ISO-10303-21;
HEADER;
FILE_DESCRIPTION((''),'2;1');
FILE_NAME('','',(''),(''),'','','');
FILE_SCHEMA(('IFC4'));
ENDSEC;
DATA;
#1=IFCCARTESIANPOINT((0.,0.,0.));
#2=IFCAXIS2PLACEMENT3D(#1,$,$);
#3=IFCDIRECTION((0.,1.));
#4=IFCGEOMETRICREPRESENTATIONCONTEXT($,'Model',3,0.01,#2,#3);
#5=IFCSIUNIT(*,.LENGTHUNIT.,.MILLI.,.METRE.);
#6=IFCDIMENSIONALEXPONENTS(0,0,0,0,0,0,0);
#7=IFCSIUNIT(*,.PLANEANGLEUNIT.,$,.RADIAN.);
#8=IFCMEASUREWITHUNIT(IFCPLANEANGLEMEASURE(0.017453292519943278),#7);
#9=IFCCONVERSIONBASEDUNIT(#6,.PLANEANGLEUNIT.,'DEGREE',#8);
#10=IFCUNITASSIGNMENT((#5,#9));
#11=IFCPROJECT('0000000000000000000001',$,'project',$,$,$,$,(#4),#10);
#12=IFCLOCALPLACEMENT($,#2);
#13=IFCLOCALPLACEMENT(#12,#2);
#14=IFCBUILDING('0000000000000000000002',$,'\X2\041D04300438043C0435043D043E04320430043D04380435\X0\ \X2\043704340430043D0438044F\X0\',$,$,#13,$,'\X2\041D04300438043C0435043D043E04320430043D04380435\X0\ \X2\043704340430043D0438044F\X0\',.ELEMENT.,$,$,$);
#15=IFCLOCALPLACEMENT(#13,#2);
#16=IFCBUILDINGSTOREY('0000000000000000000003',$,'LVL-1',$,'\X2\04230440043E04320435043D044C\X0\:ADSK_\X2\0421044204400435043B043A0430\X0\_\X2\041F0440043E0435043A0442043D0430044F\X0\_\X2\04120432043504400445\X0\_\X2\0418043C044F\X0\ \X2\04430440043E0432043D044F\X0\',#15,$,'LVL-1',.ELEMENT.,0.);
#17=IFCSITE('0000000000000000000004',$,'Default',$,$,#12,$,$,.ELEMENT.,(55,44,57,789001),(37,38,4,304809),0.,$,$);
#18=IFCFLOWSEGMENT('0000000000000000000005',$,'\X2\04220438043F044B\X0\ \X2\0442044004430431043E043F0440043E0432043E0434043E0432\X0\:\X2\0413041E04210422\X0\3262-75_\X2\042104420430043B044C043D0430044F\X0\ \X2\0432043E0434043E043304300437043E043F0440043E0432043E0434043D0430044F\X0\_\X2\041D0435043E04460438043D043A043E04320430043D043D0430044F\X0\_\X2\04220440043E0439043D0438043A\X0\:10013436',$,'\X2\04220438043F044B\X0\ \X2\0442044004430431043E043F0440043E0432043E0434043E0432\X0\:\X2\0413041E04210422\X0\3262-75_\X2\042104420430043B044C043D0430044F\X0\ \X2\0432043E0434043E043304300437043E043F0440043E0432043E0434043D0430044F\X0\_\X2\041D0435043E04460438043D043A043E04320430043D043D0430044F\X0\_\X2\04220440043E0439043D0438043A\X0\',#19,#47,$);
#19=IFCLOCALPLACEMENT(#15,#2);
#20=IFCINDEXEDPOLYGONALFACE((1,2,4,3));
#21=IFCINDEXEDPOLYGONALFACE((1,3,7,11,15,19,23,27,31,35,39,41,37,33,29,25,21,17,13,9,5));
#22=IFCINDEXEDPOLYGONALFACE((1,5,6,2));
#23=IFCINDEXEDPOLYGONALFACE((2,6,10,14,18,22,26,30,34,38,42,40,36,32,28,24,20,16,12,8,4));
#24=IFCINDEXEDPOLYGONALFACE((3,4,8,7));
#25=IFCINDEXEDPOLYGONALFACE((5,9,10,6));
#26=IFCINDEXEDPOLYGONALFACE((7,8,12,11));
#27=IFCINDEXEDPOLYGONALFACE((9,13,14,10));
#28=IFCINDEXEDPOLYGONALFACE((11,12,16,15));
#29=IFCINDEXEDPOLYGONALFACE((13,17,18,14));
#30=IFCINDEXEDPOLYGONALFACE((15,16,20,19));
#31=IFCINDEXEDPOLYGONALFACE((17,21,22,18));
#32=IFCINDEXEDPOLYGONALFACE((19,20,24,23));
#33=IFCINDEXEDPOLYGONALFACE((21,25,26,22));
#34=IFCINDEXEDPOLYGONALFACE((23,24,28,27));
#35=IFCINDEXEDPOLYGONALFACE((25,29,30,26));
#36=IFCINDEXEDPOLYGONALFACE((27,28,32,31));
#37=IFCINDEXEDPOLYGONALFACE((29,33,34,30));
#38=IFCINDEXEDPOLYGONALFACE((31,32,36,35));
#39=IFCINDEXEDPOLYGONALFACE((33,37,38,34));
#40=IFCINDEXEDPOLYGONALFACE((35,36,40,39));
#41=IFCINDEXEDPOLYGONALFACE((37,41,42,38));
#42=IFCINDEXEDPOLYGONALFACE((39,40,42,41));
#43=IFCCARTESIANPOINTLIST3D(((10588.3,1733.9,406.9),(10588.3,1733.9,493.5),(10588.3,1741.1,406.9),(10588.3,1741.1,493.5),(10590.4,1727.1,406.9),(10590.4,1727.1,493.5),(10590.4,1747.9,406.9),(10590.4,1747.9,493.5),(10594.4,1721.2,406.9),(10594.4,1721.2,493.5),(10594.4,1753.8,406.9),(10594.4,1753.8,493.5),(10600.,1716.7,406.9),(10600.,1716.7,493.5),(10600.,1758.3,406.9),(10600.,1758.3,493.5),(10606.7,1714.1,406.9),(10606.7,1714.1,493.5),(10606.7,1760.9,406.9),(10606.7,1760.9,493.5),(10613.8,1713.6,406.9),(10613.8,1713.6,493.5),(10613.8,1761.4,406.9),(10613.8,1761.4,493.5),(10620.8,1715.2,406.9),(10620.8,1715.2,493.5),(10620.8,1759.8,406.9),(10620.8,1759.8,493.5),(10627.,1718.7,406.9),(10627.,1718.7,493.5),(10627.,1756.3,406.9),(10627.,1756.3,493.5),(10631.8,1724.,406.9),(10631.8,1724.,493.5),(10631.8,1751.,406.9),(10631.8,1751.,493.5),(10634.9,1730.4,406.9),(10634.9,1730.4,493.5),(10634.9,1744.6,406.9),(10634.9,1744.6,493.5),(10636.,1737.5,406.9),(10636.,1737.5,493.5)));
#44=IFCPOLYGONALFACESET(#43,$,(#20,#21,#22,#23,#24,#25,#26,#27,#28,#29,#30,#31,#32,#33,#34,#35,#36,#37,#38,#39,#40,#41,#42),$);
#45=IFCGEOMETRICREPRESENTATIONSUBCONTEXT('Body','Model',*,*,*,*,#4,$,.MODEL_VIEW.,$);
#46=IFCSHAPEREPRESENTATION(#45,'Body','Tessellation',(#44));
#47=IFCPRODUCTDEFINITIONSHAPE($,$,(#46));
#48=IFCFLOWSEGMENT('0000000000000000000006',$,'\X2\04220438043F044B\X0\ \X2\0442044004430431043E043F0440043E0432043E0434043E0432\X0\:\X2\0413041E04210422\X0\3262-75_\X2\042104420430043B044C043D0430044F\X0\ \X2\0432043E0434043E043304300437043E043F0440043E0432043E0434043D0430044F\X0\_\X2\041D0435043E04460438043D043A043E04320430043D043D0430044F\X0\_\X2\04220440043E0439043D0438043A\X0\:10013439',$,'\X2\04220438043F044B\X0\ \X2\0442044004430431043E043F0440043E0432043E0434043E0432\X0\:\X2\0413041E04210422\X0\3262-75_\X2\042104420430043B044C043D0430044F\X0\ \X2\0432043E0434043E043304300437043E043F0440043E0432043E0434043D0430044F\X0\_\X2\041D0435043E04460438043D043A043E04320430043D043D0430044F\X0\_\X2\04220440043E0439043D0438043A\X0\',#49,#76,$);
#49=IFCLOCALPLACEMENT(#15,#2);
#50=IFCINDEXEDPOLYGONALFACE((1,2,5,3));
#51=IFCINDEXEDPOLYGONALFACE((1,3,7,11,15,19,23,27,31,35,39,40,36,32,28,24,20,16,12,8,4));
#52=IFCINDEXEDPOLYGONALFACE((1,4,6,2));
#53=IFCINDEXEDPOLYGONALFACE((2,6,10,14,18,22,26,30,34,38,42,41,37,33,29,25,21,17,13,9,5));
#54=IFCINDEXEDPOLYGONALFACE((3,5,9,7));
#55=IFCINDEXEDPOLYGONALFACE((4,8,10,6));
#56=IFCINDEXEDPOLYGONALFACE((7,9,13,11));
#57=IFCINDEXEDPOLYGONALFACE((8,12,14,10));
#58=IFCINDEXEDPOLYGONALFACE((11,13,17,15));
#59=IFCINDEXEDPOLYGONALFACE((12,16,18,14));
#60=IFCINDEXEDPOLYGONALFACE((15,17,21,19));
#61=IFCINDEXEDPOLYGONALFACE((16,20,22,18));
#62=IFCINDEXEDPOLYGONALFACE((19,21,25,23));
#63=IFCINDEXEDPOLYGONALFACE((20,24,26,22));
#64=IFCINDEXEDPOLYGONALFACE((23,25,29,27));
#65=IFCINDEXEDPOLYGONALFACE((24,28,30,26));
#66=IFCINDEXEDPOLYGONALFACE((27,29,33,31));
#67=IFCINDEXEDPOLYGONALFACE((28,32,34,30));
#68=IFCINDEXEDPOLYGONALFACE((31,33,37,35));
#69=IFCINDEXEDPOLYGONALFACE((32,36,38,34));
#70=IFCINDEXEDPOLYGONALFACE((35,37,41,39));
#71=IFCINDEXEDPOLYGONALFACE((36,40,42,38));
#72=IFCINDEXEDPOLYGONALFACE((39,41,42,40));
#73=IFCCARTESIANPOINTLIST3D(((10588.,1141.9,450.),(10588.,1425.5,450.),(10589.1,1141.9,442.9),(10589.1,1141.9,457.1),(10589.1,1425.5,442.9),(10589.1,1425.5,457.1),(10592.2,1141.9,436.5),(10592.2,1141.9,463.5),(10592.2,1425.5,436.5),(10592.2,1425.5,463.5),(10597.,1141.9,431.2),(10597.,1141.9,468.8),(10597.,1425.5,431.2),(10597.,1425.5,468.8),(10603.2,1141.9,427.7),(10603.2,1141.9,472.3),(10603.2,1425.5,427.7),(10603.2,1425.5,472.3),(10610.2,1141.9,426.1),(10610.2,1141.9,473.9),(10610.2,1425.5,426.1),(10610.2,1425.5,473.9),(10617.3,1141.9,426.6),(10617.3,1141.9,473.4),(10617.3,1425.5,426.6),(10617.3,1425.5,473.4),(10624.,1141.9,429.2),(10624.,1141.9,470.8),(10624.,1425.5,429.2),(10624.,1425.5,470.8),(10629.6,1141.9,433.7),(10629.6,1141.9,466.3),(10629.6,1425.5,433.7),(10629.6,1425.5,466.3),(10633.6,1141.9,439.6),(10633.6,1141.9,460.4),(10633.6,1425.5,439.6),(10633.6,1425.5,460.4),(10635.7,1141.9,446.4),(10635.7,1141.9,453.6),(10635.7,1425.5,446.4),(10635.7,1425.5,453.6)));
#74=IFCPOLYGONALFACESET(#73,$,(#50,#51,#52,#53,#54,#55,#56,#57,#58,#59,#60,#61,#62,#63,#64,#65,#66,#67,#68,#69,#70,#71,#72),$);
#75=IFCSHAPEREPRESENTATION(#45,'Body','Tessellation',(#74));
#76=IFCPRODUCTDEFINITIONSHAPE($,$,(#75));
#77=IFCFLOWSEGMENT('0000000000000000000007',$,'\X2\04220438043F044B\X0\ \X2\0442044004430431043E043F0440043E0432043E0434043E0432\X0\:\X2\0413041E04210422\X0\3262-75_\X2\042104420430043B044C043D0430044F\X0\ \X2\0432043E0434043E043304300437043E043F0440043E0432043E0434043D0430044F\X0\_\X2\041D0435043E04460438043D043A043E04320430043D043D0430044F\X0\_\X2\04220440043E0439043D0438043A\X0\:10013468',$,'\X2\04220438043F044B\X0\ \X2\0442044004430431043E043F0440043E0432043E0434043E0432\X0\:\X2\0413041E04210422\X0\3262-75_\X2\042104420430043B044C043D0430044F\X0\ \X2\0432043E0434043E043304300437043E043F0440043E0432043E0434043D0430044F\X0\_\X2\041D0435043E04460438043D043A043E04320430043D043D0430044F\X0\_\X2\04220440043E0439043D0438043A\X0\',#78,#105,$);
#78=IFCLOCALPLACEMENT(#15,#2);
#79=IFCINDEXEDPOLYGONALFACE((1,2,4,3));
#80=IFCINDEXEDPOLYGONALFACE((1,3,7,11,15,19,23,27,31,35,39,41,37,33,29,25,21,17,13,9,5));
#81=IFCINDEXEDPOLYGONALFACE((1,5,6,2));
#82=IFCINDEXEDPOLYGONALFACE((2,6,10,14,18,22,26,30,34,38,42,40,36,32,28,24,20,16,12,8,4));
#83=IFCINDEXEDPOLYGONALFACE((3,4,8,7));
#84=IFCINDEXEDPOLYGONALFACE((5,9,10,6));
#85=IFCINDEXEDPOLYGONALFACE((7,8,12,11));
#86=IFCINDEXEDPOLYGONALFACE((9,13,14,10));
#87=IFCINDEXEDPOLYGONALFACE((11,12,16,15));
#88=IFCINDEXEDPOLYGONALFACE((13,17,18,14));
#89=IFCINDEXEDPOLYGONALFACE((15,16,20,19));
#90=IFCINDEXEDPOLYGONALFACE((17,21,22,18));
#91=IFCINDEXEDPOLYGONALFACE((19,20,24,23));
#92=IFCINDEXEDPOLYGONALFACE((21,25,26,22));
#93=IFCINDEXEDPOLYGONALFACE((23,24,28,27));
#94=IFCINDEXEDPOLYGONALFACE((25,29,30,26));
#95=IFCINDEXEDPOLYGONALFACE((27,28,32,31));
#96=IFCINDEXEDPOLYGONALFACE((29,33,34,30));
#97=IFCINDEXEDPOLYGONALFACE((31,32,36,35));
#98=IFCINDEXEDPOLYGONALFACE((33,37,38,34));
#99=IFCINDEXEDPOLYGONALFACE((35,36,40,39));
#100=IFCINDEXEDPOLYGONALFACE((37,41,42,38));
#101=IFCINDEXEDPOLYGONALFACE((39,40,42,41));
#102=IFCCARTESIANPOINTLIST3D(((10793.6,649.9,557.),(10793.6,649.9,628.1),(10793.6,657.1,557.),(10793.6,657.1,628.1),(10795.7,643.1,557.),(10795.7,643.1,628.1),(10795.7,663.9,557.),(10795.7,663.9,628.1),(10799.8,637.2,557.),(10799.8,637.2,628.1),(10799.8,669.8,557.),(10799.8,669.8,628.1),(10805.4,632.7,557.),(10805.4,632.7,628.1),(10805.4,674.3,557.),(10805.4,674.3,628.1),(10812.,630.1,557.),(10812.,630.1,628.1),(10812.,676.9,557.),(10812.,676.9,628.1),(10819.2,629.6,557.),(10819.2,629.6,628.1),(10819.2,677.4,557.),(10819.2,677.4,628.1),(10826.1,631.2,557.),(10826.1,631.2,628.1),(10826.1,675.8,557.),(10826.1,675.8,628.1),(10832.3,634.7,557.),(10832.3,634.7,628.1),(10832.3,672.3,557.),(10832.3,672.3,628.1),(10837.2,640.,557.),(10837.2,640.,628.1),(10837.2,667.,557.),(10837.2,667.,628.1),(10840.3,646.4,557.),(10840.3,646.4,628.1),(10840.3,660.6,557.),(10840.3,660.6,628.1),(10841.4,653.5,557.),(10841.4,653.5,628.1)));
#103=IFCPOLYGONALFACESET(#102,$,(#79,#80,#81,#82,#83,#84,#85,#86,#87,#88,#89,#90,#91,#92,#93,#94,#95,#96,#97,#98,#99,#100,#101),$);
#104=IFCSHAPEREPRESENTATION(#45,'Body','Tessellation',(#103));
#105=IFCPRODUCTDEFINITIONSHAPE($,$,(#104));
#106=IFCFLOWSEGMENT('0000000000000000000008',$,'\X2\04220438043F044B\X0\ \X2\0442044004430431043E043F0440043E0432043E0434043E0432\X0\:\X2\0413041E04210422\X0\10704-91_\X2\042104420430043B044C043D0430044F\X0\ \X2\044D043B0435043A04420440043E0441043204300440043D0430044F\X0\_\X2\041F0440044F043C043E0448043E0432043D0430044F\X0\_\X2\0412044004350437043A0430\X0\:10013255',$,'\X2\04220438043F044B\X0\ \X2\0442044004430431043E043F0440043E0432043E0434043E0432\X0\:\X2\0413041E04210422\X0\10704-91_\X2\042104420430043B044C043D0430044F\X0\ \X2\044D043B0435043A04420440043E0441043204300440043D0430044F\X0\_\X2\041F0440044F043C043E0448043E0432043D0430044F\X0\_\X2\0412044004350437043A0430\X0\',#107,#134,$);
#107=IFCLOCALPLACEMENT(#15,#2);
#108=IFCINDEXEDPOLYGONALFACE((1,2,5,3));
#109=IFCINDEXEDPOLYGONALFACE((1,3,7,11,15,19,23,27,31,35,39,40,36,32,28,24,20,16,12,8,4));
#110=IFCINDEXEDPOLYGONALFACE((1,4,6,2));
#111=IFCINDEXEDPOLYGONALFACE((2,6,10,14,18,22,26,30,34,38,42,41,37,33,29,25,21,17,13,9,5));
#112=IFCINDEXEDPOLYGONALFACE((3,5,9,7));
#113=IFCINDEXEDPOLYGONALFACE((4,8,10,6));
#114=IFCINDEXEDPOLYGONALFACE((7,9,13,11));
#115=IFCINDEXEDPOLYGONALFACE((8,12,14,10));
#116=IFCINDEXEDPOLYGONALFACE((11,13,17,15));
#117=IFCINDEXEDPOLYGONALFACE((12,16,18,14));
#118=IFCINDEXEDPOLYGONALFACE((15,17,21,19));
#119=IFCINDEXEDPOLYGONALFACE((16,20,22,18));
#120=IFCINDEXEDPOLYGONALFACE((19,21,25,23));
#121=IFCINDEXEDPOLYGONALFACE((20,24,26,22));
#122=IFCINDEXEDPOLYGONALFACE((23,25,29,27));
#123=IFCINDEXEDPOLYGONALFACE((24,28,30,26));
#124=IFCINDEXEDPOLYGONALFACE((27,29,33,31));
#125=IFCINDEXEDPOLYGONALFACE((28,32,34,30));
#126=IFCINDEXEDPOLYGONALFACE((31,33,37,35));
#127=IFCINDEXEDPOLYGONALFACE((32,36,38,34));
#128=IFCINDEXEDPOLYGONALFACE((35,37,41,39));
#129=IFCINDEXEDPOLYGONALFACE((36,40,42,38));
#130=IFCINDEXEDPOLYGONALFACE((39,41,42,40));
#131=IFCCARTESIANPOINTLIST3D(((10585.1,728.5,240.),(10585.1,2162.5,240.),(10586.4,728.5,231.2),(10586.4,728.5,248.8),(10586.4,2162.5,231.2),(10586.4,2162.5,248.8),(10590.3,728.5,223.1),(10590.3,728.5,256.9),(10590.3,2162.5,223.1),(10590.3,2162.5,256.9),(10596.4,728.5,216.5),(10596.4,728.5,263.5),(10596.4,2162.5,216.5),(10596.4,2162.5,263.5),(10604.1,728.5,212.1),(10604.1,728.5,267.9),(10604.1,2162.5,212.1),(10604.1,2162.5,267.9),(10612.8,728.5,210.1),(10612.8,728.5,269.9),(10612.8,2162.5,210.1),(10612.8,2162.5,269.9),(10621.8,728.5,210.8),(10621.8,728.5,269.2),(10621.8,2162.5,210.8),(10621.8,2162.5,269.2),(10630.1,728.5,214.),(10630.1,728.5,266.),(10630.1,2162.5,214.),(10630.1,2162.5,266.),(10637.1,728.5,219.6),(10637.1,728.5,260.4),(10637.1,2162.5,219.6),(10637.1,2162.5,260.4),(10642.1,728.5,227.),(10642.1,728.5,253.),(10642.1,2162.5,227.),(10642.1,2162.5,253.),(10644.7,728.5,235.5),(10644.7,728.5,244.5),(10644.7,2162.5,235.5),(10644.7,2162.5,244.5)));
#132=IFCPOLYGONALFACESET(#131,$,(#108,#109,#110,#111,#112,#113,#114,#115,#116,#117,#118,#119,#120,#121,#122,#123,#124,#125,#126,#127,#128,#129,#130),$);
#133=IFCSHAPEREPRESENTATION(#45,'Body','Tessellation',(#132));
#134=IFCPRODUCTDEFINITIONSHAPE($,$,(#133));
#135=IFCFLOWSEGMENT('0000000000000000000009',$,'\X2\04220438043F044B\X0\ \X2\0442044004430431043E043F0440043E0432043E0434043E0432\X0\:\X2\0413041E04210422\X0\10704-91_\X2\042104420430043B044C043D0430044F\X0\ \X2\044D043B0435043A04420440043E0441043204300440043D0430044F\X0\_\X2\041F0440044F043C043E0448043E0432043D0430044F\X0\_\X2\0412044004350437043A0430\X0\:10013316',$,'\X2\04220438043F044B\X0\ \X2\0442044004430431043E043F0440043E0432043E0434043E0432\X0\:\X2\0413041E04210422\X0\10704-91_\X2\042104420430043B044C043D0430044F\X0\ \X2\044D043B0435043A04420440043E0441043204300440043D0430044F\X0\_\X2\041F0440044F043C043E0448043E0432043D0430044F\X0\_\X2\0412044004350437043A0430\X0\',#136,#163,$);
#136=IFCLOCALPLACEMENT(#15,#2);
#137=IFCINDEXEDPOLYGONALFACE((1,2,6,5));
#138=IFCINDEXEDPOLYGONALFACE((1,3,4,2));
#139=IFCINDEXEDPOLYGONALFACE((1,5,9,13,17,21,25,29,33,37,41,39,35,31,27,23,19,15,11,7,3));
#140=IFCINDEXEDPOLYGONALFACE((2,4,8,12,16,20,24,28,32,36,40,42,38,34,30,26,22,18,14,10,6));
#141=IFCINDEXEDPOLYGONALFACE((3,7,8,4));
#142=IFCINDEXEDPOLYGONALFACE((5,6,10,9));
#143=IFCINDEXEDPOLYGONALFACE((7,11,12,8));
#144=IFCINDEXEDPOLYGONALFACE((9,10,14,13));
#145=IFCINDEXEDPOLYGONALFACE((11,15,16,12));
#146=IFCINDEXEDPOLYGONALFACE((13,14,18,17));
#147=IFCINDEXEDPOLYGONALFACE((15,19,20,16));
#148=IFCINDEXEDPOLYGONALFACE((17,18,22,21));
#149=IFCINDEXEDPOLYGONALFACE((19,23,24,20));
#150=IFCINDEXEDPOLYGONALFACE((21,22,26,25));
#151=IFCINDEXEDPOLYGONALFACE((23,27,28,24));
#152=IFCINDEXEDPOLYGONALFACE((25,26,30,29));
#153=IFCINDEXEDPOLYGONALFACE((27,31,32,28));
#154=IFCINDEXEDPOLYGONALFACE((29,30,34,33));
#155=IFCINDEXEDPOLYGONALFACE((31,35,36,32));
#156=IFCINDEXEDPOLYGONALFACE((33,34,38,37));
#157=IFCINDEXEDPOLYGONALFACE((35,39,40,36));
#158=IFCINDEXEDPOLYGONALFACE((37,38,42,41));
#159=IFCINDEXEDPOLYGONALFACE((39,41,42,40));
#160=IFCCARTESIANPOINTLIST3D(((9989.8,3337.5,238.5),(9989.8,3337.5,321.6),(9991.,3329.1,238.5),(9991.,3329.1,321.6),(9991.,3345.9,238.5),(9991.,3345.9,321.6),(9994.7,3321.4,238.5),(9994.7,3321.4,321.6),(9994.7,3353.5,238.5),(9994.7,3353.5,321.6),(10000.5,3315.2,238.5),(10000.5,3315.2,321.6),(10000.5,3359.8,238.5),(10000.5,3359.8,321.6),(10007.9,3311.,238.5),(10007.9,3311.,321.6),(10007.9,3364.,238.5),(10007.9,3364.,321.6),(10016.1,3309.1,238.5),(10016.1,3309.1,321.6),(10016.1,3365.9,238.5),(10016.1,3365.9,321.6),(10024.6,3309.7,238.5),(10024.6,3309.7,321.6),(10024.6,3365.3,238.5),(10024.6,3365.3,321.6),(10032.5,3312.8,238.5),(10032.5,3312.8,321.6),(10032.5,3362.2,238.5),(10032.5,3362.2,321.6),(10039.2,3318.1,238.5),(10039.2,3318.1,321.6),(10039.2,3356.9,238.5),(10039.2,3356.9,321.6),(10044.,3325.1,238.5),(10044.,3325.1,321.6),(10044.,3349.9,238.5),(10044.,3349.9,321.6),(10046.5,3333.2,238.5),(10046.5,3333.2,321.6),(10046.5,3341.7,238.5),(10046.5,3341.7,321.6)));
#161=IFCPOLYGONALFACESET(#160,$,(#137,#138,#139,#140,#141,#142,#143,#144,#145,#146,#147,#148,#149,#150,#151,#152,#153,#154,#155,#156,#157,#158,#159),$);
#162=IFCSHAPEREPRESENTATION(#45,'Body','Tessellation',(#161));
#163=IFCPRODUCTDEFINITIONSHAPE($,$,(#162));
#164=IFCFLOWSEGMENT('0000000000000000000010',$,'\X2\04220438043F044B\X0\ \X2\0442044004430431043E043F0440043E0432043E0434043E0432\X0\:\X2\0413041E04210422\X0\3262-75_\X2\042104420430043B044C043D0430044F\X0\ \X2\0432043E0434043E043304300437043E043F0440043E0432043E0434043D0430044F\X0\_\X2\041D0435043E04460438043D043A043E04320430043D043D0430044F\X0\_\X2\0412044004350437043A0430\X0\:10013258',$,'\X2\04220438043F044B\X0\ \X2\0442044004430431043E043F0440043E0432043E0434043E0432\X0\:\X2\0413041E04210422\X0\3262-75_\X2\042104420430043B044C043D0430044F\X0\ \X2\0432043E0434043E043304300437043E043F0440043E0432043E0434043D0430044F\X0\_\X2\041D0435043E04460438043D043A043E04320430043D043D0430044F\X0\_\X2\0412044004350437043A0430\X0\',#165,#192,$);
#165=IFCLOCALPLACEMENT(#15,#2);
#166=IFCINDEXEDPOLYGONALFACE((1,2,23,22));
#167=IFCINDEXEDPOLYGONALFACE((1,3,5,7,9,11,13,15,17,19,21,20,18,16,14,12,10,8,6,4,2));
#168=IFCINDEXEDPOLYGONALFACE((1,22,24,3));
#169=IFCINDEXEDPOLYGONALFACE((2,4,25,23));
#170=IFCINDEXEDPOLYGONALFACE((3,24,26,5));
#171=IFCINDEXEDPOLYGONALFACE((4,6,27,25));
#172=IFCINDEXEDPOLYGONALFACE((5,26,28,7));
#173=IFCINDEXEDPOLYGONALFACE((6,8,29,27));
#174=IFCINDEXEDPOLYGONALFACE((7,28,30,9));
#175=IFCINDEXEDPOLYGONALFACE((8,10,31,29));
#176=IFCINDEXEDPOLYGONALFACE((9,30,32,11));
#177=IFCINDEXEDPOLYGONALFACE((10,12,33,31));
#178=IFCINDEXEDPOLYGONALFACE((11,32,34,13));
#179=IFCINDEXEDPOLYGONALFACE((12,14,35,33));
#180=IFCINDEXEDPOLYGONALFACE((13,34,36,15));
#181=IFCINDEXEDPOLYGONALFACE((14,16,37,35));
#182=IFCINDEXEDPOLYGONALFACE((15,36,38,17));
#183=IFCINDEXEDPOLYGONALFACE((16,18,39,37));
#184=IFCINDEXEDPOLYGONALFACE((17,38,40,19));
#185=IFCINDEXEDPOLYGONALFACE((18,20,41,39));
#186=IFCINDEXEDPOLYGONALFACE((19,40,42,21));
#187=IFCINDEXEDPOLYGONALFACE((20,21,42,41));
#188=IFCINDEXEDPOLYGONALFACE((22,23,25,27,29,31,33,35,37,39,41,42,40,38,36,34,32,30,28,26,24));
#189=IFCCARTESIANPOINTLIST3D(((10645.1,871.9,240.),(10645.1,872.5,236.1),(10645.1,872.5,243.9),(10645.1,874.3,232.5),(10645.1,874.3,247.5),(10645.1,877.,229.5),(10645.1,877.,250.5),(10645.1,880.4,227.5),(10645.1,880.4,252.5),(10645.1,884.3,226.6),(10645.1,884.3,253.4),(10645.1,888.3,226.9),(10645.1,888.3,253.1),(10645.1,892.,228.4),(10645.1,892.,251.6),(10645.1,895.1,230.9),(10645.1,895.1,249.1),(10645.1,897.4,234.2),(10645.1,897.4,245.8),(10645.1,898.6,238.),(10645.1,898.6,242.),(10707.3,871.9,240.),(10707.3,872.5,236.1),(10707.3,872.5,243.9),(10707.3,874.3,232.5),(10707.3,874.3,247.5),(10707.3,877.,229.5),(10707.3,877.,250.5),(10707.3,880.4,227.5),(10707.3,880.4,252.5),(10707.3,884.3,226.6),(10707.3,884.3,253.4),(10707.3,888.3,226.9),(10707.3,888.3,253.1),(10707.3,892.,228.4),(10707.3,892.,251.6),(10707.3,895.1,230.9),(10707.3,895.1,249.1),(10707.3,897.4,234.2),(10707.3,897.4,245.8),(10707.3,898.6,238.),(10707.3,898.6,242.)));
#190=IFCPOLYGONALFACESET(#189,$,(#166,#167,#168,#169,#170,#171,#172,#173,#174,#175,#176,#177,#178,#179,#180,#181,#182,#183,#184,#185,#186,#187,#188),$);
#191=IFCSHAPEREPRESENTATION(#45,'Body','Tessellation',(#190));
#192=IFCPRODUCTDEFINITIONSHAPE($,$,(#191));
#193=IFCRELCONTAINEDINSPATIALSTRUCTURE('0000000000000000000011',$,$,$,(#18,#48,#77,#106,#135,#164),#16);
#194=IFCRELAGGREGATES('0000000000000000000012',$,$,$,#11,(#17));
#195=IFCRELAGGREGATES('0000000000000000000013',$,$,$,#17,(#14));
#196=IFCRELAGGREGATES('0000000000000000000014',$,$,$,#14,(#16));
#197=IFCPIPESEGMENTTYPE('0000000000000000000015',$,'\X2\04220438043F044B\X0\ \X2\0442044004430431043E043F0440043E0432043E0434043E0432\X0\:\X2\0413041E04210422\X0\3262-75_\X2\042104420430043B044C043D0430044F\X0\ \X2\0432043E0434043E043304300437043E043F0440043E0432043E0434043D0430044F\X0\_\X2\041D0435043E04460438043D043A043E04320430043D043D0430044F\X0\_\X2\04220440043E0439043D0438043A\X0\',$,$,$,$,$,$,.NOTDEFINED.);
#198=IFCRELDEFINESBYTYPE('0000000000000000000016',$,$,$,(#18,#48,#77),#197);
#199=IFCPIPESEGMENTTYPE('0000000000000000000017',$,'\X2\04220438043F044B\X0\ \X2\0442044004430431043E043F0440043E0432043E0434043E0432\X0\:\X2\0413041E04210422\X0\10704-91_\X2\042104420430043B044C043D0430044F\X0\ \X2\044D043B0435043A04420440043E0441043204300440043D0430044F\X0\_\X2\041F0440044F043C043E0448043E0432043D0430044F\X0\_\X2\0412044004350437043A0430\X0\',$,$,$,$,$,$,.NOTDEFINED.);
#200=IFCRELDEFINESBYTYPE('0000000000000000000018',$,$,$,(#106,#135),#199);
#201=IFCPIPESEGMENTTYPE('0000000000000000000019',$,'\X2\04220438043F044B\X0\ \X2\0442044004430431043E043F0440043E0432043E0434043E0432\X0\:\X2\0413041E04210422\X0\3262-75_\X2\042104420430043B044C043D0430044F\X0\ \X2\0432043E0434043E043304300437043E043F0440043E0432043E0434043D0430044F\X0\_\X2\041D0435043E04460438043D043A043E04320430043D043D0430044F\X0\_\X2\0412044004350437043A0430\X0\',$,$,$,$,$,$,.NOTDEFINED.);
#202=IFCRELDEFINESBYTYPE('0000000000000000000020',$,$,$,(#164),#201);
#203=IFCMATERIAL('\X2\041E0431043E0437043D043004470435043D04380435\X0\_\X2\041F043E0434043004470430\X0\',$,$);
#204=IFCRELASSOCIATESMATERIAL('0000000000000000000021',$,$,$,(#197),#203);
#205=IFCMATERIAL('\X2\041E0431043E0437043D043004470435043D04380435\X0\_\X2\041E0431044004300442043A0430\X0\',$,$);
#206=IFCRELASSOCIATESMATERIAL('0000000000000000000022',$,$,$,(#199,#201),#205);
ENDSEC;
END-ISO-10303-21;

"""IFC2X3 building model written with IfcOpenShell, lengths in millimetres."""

from ifc_helpers import new_model, entity, si_unit, converted_unit, direction, frame, frame_2d, origin, origin_2d_with_axis, place, context, subcontext, project, spatial, circle, extrude, material, type_object, element, save


model = new_model("IFC2X3")

# Units and contexts
model_context = context("Model", 3, precision=0.01, world=origin(), true_north=direction((0.0, 1.0)))
body_context = subcontext(model_context, "Body", "Model", "MODEL_VIEW")
ifc_project = project(units=[si_unit("LENGTHUNIT", "METRE", prefix="MILLI"), converted_unit("PLANEANGLEUNIT", "DEGREE", entity("IfcPlaneAngleMeasure", 0.017453292519943278), si_unit("PLANEANGLEUNIT", "RADIAN"), dimensions=[0, 0, 0, 0, 0, 0, 0])], contexts=[model_context])

# Site, building, storey
site_placement = place(None, origin())
site = spatial("IfcSite", under=ifc_project, at=site_placement, Name="Default", CompositionType="ELEMENT", RefLatitude=(55, 44, 57, 789001), RefLongitude=(37, 38, 4, 304809), RefElevation=0.0)
building_placement = place(site_placement, origin())
building = spatial("IfcBuilding", under=site, at=building_placement, Name="Наименование здания", LongName="Наименование здания", CompositionType="ELEMENT")
storey_placement = place(building_placement, origin())
storey = spatial("IfcBuildingStorey", under=building, at=storey_placement, Name="LVL-1", ObjectType="Уровень:ADSK_Стрелка_Проектная_Вверх_Имя уровня", LongName="LVL-1", CompositionType="ELEMENT", Elevation=0.0)

# Flow segments
ifc_material_1 = material(Name="Обозначение_Подача")
pipe_segment_type_1 = type_object("IfcPipeSegmentType", Name="Типы трубопроводов:ГОСТ3262-75_Стальная водогазопроводная_Неоцинкованная_Тройник", PredefinedType="NOTDEFINED", material=ifc_material_1)
flow_segment_1_placement = place(storey_placement, origin())
element("IfcFlowSegment", 1, at=flow_segment_1_placement, inside=storey, type_object=pipe_segment_type_1, Name="Типы трубопроводов:ГОСТ3262-75_Стальная водогазопроводная_Неоцинкованная_Тройник:10013436", ObjectType="Типы трубопроводов:ГОСТ3262-75_Стальная водогазопроводная_Неоцинкованная_Тройник", context=body_context, shape_type="SweptSolid", body=[
    extrude(circle(Radius=24.0, at=origin_2d_with_axis()), frame((10612.0, 1737.5, 406.9)), (0.0, 0.0, 1.0), 86.6),
])
flow_segment_2_placement = place(storey_placement, origin())
element("IfcFlowSegment", 2, at=flow_segment_2_placement, inside=storey, type_object=pipe_segment_type_1, Name="Типы трубопроводов:ГОСТ3262-75_Стальная водогазопроводная_Неоцинкованная_Тройник:10013439", ObjectType="Типы трубопроводов:ГОСТ3262-75_Стальная водогазопроводная_Неоцинкованная_Тройник", context=body_context, shape_type="SweptSolid", body=[
    extrude(circle(Radius=24.0, at=origin_2d_with_axis()), frame((10612.0, 1141.9, 450.0), z_axis=(0.0, 1.0, 0.0), x_axis=(-1.0, 0.0, 0.0)), (0.0, 0.0, 1.0), 283.6),
])
flow_segment_3_placement = place(storey_placement, origin())
element("IfcFlowSegment", 3, at=flow_segment_3_placement, inside=storey, type_object=pipe_segment_type_1, Name="Типы трубопроводов:ГОСТ3262-75_Стальная водогазопроводная_Неоцинкованная_Тройник:10013468", ObjectType="Типы трубопроводов:ГОСТ3262-75_Стальная водогазопроводная_Неоцинкованная_Тройник", context=body_context, shape_type="SweptSolid", body=[
    extrude(circle(Radius=24.0, at=origin_2d_with_axis()), frame((10817.4, 653.5, 557.0)), (0.0, 0.0, 1.0), 71.1),
])
ifc_material_2 = material(Name="Обозначение_Обратка")
pipe_segment_type_2 = type_object("IfcPipeSegmentType", Name="Типы трубопроводов:ГОСТ10704-91_Стальная электросварная_Прямошовная_Врезка", PredefinedType="NOTDEFINED", material=ifc_material_2)
flow_segment_4_placement = place(storey_placement, origin())
element("IfcFlowSegment", 4, at=flow_segment_4_placement, inside=storey, type_object=pipe_segment_type_2, Name="Типы трубопроводов:ГОСТ10704-91_Стальная электросварная_Прямошовная_Врезка:10013255", ObjectType="Типы трубопроводов:ГОСТ10704-91_Стальная электросварная_Прямошовная_Врезка", context=body_context, shape_type="SweptSolid", body=[
    extrude(circle(Radius=30.0, at=frame_2d((0.0, 0.0), x_axis=(1.0, 0.0))), frame((10615.1, 728.5, 240.0), z_axis=(0.0, 1.0, 0.0), x_axis=(-1.0, 0.0, 0.0)), (0.0, 0.0, 1.0), 1434.0),
])
flow_segment_5_placement = place(storey_placement, origin())
element("IfcFlowSegment", 5, at=flow_segment_5_placement, inside=storey, type_object=pipe_segment_type_2, Name="Типы трубопроводов:ГОСТ10704-91_Стальная электросварная_Прямошовная_Врезка:10013316", ObjectType="Типы трубопроводов:ГОСТ10704-91_Стальная электросварная_Прямошовная_Врезка", context=body_context, shape_type="SweptSolid", body=[
    extrude(circle(Radius=28.5, at=origin_2d_with_axis()), frame((10018.3, 3337.5, 238.5), z_axis=(0.0, 0.0, 1.0), x_axis=(-1.0, 0.0, 0.0)), (0.0, 0.0, 1.0), 83.1),
])
pipe_segment_type_3 = type_object("IfcPipeSegmentType", Name="Типы трубопроводов:ГОСТ3262-75_Стальная водогазопроводная_Неоцинкованная_Врезка", PredefinedType="NOTDEFINED", material=ifc_material_2)
flow_segment_6_placement = place(storey_placement, origin())
element("IfcFlowSegment", 6, at=flow_segment_6_placement, inside=storey, type_object=pipe_segment_type_3, Name="Типы трубопроводов:ГОСТ3262-75_Стальная водогазопроводная_Неоцинкованная_Врезка:10013258", ObjectType="Типы трубопроводов:ГОСТ3262-75_Стальная водогазопроводная_Неоцинкованная_Врезка", context=body_context, shape_type="SweptSolid", body=[
    extrude(circle(Radius=13.4, at=frame_2d((0.0, 0.0), x_axis=(1.0, 0.0))), frame((10645.1, 885.3, 240.0), z_axis=(1.0, 0.0, 0.0), x_axis=(0.0, -1.0, 0.0)), (0.0, 0.0, 1.0), 62.2),
])

save(model, "model.ifc")
